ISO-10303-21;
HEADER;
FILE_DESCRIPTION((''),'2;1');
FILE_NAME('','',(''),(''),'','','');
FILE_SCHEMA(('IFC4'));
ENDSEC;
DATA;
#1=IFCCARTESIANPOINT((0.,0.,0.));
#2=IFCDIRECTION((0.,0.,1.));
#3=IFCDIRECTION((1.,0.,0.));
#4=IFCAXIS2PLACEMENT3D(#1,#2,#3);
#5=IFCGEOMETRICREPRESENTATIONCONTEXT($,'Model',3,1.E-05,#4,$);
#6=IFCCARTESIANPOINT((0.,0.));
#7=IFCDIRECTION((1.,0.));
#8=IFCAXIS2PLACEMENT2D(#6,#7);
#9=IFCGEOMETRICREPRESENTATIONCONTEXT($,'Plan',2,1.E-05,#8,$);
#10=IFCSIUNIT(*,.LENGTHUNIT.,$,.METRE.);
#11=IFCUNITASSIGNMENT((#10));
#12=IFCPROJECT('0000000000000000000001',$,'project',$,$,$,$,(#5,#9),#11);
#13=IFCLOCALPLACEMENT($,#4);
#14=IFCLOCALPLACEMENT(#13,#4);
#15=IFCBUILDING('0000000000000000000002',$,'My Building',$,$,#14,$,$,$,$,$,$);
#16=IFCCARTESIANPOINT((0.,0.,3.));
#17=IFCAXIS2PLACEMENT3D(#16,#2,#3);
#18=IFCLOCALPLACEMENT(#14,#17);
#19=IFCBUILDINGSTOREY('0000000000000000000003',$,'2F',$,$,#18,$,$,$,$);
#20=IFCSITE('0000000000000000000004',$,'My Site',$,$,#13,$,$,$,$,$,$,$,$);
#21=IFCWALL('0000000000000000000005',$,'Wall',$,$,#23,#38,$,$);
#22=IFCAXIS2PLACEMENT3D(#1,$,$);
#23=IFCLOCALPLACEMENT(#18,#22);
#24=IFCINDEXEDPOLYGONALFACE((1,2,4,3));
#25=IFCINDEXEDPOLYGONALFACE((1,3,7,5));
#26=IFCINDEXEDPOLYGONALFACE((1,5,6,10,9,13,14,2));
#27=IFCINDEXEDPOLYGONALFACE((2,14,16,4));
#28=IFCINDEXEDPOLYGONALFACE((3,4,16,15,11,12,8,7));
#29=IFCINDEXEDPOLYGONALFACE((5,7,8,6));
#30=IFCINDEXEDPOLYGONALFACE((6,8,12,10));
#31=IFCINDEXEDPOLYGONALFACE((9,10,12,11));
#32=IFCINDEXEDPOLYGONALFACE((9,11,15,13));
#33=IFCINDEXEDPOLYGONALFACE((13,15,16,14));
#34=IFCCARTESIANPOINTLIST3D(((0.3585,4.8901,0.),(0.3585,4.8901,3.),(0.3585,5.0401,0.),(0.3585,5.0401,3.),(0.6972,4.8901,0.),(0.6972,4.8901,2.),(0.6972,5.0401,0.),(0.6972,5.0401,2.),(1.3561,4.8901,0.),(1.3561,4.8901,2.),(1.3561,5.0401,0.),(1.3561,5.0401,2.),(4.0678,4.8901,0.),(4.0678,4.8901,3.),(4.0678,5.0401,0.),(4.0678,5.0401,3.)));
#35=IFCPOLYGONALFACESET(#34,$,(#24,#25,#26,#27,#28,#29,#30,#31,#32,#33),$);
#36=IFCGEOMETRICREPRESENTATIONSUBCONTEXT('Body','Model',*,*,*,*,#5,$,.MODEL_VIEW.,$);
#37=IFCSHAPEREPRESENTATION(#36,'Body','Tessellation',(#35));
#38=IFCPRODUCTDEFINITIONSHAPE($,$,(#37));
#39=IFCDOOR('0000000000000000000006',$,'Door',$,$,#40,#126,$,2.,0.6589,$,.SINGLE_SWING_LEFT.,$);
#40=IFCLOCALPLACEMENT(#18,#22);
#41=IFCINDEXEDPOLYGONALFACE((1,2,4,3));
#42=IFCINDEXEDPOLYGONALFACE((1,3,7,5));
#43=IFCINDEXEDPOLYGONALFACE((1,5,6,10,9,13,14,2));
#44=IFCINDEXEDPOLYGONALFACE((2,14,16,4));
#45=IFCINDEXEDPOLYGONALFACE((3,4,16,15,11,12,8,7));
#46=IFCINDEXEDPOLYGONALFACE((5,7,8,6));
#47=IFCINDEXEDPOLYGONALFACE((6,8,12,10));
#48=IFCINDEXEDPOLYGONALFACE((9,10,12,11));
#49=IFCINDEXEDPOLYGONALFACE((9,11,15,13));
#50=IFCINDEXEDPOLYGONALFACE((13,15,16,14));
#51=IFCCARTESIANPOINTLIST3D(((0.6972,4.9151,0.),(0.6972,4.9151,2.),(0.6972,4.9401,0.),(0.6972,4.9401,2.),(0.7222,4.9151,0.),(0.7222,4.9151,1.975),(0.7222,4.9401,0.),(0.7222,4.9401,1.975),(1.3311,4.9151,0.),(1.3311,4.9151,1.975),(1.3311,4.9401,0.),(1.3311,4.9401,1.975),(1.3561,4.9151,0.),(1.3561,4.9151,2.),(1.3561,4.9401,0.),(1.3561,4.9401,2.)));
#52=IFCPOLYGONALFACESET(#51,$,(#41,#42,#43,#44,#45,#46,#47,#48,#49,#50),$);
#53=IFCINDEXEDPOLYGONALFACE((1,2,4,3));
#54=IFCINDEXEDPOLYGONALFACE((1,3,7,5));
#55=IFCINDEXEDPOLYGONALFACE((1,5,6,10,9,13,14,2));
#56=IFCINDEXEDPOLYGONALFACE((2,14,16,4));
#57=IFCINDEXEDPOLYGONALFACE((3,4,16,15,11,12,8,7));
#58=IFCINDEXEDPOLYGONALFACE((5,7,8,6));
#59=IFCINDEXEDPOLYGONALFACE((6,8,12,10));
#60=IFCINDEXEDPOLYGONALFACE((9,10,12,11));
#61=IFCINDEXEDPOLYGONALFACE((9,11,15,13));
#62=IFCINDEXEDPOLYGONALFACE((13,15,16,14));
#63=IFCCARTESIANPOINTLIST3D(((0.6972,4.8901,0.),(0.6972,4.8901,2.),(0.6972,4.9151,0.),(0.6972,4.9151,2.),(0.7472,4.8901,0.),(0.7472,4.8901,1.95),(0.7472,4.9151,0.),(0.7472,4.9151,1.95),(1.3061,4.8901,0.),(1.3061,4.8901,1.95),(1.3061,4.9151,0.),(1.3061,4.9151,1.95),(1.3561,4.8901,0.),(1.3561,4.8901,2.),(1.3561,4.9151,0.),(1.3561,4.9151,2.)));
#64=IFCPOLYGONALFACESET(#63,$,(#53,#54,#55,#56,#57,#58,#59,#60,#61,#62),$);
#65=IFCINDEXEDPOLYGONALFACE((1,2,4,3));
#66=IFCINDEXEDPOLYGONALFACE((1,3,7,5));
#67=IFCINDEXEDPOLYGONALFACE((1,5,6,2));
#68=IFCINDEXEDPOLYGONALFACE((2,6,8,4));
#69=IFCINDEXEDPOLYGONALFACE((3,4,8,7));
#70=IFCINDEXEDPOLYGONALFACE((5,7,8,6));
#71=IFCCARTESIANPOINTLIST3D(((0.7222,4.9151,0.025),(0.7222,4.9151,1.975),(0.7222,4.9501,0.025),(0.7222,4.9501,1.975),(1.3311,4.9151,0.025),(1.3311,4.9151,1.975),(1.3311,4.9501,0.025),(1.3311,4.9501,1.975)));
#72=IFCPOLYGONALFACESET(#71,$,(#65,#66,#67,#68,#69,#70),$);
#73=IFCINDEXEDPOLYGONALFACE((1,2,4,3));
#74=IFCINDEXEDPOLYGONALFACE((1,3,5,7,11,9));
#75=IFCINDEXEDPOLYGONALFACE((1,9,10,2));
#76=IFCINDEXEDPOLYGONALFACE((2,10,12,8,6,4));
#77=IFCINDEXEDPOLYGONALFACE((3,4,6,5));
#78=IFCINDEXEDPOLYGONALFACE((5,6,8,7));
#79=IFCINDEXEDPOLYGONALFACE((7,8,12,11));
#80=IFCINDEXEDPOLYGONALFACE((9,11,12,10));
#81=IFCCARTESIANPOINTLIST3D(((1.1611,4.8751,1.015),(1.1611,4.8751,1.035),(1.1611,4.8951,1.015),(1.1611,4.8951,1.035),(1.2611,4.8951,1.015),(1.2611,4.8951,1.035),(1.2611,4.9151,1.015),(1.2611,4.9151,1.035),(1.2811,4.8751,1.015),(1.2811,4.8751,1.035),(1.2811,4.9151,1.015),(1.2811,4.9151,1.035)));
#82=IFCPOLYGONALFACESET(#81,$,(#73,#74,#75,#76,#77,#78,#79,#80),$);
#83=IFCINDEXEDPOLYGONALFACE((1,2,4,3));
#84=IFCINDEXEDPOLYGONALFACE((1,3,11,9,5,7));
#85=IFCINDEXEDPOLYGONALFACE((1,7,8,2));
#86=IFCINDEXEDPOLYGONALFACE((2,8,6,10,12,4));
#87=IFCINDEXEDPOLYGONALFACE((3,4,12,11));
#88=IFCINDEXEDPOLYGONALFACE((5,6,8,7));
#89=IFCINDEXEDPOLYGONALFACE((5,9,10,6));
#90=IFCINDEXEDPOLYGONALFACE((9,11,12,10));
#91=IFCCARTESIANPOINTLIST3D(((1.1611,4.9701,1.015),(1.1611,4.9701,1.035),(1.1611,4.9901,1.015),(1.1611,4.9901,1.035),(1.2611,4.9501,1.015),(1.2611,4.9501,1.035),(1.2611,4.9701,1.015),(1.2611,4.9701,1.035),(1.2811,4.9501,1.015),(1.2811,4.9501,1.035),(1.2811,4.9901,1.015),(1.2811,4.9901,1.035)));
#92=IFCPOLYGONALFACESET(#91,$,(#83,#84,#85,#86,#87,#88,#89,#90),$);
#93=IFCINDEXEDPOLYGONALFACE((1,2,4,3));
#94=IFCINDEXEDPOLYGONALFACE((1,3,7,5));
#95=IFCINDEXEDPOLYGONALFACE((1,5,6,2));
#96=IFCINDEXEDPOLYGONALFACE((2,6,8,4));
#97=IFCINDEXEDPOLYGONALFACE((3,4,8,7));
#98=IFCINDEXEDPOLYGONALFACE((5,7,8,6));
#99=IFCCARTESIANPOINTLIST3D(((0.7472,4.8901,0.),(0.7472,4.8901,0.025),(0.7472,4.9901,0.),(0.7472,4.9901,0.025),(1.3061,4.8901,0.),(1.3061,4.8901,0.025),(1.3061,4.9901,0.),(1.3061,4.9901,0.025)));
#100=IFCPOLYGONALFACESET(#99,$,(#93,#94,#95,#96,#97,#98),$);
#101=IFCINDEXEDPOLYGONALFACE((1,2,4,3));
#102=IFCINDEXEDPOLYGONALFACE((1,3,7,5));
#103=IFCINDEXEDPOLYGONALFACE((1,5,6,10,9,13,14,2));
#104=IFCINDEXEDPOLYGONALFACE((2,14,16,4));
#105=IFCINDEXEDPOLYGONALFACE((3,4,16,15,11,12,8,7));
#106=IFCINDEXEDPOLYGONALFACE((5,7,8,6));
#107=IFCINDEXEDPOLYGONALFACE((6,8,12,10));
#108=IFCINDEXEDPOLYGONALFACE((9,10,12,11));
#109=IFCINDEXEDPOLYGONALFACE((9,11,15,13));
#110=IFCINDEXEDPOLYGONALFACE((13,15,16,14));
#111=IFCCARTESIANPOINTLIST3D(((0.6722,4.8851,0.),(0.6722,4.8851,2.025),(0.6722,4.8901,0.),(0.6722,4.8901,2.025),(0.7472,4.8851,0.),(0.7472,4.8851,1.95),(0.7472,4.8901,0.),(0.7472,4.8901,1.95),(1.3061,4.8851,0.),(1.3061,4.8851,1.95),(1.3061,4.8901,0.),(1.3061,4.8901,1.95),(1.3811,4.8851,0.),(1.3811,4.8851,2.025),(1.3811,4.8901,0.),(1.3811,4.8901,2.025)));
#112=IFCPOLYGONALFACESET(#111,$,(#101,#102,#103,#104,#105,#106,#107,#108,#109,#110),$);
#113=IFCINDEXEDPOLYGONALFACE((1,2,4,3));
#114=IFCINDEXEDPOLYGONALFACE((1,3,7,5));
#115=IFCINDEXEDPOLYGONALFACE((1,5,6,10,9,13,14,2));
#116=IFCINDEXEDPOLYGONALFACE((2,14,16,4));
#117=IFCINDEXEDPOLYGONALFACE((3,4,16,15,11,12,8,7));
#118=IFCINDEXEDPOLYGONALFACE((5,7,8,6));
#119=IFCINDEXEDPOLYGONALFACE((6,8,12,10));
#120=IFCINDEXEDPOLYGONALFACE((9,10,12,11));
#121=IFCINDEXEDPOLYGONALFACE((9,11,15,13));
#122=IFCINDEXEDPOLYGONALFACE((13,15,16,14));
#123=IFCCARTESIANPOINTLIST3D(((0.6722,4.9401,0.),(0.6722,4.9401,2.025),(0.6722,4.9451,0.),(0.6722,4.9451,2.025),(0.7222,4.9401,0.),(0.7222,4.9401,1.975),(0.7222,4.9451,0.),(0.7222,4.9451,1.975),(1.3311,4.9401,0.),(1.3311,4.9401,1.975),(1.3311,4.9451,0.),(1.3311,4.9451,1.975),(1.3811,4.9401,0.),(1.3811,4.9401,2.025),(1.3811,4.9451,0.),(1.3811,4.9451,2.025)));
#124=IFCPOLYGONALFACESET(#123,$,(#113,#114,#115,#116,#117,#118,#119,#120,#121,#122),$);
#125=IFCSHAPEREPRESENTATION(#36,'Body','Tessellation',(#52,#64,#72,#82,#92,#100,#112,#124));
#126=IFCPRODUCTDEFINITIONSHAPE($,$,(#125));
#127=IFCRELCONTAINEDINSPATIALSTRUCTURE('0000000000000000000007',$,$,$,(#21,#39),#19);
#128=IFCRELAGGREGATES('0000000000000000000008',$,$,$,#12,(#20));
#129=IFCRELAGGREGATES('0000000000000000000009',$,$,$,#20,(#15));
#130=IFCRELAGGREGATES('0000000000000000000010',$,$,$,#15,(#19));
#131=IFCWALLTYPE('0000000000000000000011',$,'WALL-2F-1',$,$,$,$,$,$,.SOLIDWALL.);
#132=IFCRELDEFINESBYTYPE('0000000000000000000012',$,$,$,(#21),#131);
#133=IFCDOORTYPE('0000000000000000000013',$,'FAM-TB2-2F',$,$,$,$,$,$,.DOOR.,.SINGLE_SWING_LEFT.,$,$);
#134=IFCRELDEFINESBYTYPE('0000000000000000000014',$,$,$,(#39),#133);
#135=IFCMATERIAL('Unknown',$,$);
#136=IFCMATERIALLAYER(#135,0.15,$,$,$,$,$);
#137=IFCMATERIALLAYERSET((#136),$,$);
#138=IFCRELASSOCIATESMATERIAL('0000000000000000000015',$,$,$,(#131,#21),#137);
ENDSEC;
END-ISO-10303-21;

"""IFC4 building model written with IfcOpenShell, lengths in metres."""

from ifc_helpers import new_model, entity, si_unit, frame, origin_with_axes, origin_2d_with_axis, place, context, subcontext, project, spatial, line, indexed_curve, outline, extrude, shape, source, transform, mapped, material, layer, layer_set, layer_usage, type_object, type_shapes, element, fill, save


model = new_model("IFC4")

# Units and contexts
model_context = context("Model", 3, precision=1e-05, world=origin_with_axes())
plan_context = context("Plan", 2, precision=1e-05, world=origin_2d_with_axis())
body_context_1 = subcontext(model_context, "Body", "Model", "MODEL_VIEW")
body_context_2 = subcontext(plan_context, "Body", "Plan", "PLAN_VIEW")
ifc_project = project(units=[si_unit("LENGTHUNIT", "METRE")], contexts=[model_context, plan_context])

# Site, building, storey
site_placement = place(None, origin_with_axes())
site = spatial("IfcSite", under=ifc_project, at=site_placement, Name="My Site")
building_placement = place(site_placement, origin_with_axes())
building = spatial("IfcBuilding", under=site, at=building_placement, Name="My Building")
storey_placement = place(building_placement, frame((0.0, 0.0, 3.0), z_axis=(0.0, 0.0, 1.0), x_axis=(1.0, 0.0, 0.0)))
storey = spatial("IfcBuildingStorey", under=building, at=storey_placement, Name="2F")

# Shared definitions
ifc_material = material(Name="Unknown")

# Shared definitions
ifc_layer_1 = layer(ifc_material, 0.15)
ifc_layer_set_1 = layer_set([ifc_layer_1])
wall_type_1 = type_object("IfcWallType", Name="WALL-2F-1", PredefinedType="SOLIDWALL", material=ifc_layer_set_1)

# Wall, opening, door
ifc_layer_usage_1 = layer_usage(ifc_layer_set_1, "AXIS2", "POSITIVE", 0.0)
wall_1_placement = place(storey_placement, frame((4.2178, 5.0401, 0.0), z_axis=(0.0, 0.0, 1.0), x_axis=(-1.0, 0.0, 0.0)))
wall_1 = element("IfcWall", 1, at=wall_1_placement, inside=storey, type_object=wall_type_1, material=ifc_layer_usage_1, Name="Wall", context=body_context_1, shape_type="SweptSolid", body=[
    extrude(outline(indexed_curve([(0.15, 0.0), (0.15, 0.15), (3.8593, 0.15), (3.8593, 0.0)], segments=[line(1, 2, 3, 4, 1)])), origin_with_axes(), (0.0, 0.0, 1.0), 3.0),
])
shared_shape_1 = source(origin_with_axes(), body_context_1, "Body", "SweptSolid", [
    extrude(outline(indexed_curve([(0.0, 0.0), (0.6589, 0.0), (0.6589, 2.0), (0.0, 2.0)], segments=[line(1, 2, 3, 4, 1)])), frame((0.0, -0.6, 0.0), z_axis=(0.0, -1.0, 0.0), x_axis=(1.0, 0.0, 0.0)), (0.0, 0.0, -1.0), 1.2),
])
opening_1_placement = place(wall_1_placement, frame((3.5206, 0.15, 0.0), z_axis=(0.0, 0.0, 1.0), x_axis=(-1.0, 0.0, 0.0)))
opening_1 = element("IfcOpeningElement", 2, at=opening_1_placement, cuts=wall_1, PredefinedType="OPENING", context=body_context_1, shape_type="MappedRepresentation", body=[
    mapped(shared_shape_1, transform((0.0, 0.0, 0.0), x_axis=(1.0, 0.0, 0.0), y_axis=(0.0, 1.0, 0.0), z_axis=(0.0, 0.0, 1.0), scale=1.0)),
])
door_type_1 = type_object("IfcDoorType", Name="FAM-TB2-2F", OperationType="SINGLE_SWING_LEFT", PredefinedType="DOOR")
shared_shape_2 = source(origin_with_axes(), body_context_1, "Body", "SweptSolid", [
    extrude(outline(indexed_curve([(0.0, 0.0), (0.0, 2.0), (0.6589, 2.0), (0.6589, 0.0), (0.6339, 0.0), (0.6339, 1.975), (0.025, 1.975), (0.025, 0.0)], segments=[line(1, 2, 3, 4, 5, 6, 7, 8, 1)])), frame((0.0, 0.025, 0.0), z_axis=(0.0, -1.0, 0.0), x_axis=(1.0, 0.0, 0.0)), (0.0, 0.0, -1.0), 0.025),
    extrude(outline(indexed_curve([(0.0, 0.0), (0.0, 2.0), (0.6589, 2.0), (0.6589, 0.0), (0.6089, 0.0), (0.6089, 1.95), (0.05, 1.95), (0.05, 0.0)], segments=[line(1, 2, 3, 4, 5, 6, 7, 8, 1)])), frame((0.0, 0.0, 0.0), z_axis=(0.0, -1.0, 0.0), x_axis=(1.0, 0.0, 0.0)), (0.0, 0.0, -1.0), 0.025),
    extrude(outline(indexed_curve([(0.0, 0.0), (0.6089, 0.0), (0.6089, 0.035), (0.0, 0.035)], segments=[line(1, 2, 3, 4, 1)])), frame((0.025, 0.025, 0.025), z_axis=(0.0, 0.0, 1.0), x_axis=(1.0, 0.0, 0.0)), (0.0, 0.0, 1.0), 1.95),
    extrude(outline(indexed_curve([(0.0, 0.0), (0.0, -0.04), (-0.12, -0.04), (-0.12, -0.02), (-0.02, -0.02), (-0.02, 0.0)], segments=[line(1, 2, 3, 4, 5, 6, 1)])), frame((0.5839, 0.025, 1.015), z_axis=(0.0, 0.0, 1.0), x_axis=(1.0, 0.0, 0.0)), (0.0, 0.0, 1.0), 0.02),
    extrude(outline(indexed_curve([(0.0, 0.0), (0.0, 0.04), (-0.12, 0.04), (-0.12, 0.02), (-0.02, 0.02), (-0.02, 0.0)], segments=[line(1, 2, 3, 4, 5, 6, 1)])), frame((0.5839, 0.06, 1.015), z_axis=(0.0, 0.0, 1.0), x_axis=(1.0, 0.0, 0.0)), (0.0, 0.0, 1.0), 0.02),
    extrude(outline(indexed_curve([(0.0, 0.0), (0.5589, 0.0), (0.5589, 0.1), (0.0, 0.1)], segments=[line(1, 2, 3, 4, 1)])), frame((0.05, 0.0, 0.0), z_axis=(0.0, 0.0, 1.0), x_axis=(1.0, 0.0, 0.0)), (0.0, 0.0, 1.0), 0.025),
    extrude(outline(indexed_curve([(0.0, 0.0), (0.0, 2.025), (0.7089, 2.025), (0.7089, 0.0), (0.6339, 0.0), (0.6339, 1.95), (0.075, 1.95), (0.075, 0.0)], segments=[line(1, 2, 3, 4, 5, 6, 7, 8, 1)])), frame((-0.025, -0.005, 0.0), z_axis=(0.0, -1.0, 0.0), x_axis=(1.0, 0.0, 0.0)), (0.0, 0.0, -1.0), 0.005),
    extrude(outline(indexed_curve([(0.0, 0.0), (0.0, 2.025), (0.7089, 2.025), (0.7089, 0.0), (0.6589, 0.0), (0.6589, 1.975), (0.05, 1.975), (0.05, 0.0)], segments=[line(1, 2, 3, 4, 5, 6, 7, 8, 1)])), frame((-0.025, 0.05, 0.0), z_axis=(0.0, -1.0, 0.0), x_axis=(1.0, 0.0, 0.0)), (0.0, 0.0, -1.0), 0.005),
])
shared_shape_3 = source(origin_with_axes(), body_context_2, "Body", "Curve2D", [
    entity("IfcIndexedPolyCurve", entity("IfcCartesianPointList2D", [[0.0, 0.0], [0.0, 0.05], [0.025, 0.05], [0.025, 0.025], [0.05, 0.025], [0.05, 0.0]]), [entity("IfcLineIndex", [1, 2, 3, 4, 5, 6, 1])]),
    entity("IfcIndexedPolyCurve", entity("IfcCartesianPointList2D", [[0.6589, 0.0], [0.6589, 0.05], [0.6339, 0.05], [0.6339, 0.025], [0.6089, 0.025], [0.6089, 0.0]]), [entity("IfcLineIndex", [1, 2, 3, 4, 5, 6, 1])]),
    entity("IfcTrimmedCurve", entity("IfcEllipse", entity("IfcAxis2Placement2D", entity("IfcCartesianPoint", [0.06, 0.05]), entity("IfcDirection", [1.0, 0.0])), 0.5739, 0.6089), [entity("IfcCartesianPoint", [0.6339, 0.05])], [entity("IfcCartesianPoint", [0.06, 0.6589])], True, "CARTESIAN"),
    entity("IfcIndexedPolyCurve", entity("IfcCartesianPointList2D", [[0.025, 0.05], [0.06, 0.05], [0.06, 0.6589], [0.025, 0.6589]]), [entity("IfcLineIndex", [1, 2, 3, 4, 1])]),
])
type_shapes(door_type_1, [shared_shape_2, shared_shape_3])
door_1_placement = place(opening_1_placement, frame((0.0, 0.0, 0.0), z_axis=(0.0, 0.0, 1.0), x_axis=(1.0, 0.0, 0.0)))
door_1 = element("IfcDoor", 3, at=door_1_placement, inside=storey, type_object=door_type_1, Name="Door", OperationType="SINGLE_SWING_LEFT", OverallHeight=2.0, OverallWidth=0.6589, shapes=[
    shape(body_context_1, "Body", "MappedRepresentation", [mapped(shared_shape_2, transform((0.0, 0.0, 0.0), x_axis=(1.0, 0.0, 0.0), y_axis=(0.0, 1.0, 0.0), z_axis=(0.0, 0.0, 1.0), scale=1.0))]),
    shape(body_context_2, "Body", "MappedRepresentation", [mapped(shared_shape_3, transform((0.0, 0.0, 0.0), x_axis=(1.0, 0.0, 0.0), y_axis=(0.0, 1.0, 0.0), z_axis=(0.0, 0.0, 1.0), scale=1.0))]),
])
fill(opening_1, door_1)

save(model, "model.ifc")
